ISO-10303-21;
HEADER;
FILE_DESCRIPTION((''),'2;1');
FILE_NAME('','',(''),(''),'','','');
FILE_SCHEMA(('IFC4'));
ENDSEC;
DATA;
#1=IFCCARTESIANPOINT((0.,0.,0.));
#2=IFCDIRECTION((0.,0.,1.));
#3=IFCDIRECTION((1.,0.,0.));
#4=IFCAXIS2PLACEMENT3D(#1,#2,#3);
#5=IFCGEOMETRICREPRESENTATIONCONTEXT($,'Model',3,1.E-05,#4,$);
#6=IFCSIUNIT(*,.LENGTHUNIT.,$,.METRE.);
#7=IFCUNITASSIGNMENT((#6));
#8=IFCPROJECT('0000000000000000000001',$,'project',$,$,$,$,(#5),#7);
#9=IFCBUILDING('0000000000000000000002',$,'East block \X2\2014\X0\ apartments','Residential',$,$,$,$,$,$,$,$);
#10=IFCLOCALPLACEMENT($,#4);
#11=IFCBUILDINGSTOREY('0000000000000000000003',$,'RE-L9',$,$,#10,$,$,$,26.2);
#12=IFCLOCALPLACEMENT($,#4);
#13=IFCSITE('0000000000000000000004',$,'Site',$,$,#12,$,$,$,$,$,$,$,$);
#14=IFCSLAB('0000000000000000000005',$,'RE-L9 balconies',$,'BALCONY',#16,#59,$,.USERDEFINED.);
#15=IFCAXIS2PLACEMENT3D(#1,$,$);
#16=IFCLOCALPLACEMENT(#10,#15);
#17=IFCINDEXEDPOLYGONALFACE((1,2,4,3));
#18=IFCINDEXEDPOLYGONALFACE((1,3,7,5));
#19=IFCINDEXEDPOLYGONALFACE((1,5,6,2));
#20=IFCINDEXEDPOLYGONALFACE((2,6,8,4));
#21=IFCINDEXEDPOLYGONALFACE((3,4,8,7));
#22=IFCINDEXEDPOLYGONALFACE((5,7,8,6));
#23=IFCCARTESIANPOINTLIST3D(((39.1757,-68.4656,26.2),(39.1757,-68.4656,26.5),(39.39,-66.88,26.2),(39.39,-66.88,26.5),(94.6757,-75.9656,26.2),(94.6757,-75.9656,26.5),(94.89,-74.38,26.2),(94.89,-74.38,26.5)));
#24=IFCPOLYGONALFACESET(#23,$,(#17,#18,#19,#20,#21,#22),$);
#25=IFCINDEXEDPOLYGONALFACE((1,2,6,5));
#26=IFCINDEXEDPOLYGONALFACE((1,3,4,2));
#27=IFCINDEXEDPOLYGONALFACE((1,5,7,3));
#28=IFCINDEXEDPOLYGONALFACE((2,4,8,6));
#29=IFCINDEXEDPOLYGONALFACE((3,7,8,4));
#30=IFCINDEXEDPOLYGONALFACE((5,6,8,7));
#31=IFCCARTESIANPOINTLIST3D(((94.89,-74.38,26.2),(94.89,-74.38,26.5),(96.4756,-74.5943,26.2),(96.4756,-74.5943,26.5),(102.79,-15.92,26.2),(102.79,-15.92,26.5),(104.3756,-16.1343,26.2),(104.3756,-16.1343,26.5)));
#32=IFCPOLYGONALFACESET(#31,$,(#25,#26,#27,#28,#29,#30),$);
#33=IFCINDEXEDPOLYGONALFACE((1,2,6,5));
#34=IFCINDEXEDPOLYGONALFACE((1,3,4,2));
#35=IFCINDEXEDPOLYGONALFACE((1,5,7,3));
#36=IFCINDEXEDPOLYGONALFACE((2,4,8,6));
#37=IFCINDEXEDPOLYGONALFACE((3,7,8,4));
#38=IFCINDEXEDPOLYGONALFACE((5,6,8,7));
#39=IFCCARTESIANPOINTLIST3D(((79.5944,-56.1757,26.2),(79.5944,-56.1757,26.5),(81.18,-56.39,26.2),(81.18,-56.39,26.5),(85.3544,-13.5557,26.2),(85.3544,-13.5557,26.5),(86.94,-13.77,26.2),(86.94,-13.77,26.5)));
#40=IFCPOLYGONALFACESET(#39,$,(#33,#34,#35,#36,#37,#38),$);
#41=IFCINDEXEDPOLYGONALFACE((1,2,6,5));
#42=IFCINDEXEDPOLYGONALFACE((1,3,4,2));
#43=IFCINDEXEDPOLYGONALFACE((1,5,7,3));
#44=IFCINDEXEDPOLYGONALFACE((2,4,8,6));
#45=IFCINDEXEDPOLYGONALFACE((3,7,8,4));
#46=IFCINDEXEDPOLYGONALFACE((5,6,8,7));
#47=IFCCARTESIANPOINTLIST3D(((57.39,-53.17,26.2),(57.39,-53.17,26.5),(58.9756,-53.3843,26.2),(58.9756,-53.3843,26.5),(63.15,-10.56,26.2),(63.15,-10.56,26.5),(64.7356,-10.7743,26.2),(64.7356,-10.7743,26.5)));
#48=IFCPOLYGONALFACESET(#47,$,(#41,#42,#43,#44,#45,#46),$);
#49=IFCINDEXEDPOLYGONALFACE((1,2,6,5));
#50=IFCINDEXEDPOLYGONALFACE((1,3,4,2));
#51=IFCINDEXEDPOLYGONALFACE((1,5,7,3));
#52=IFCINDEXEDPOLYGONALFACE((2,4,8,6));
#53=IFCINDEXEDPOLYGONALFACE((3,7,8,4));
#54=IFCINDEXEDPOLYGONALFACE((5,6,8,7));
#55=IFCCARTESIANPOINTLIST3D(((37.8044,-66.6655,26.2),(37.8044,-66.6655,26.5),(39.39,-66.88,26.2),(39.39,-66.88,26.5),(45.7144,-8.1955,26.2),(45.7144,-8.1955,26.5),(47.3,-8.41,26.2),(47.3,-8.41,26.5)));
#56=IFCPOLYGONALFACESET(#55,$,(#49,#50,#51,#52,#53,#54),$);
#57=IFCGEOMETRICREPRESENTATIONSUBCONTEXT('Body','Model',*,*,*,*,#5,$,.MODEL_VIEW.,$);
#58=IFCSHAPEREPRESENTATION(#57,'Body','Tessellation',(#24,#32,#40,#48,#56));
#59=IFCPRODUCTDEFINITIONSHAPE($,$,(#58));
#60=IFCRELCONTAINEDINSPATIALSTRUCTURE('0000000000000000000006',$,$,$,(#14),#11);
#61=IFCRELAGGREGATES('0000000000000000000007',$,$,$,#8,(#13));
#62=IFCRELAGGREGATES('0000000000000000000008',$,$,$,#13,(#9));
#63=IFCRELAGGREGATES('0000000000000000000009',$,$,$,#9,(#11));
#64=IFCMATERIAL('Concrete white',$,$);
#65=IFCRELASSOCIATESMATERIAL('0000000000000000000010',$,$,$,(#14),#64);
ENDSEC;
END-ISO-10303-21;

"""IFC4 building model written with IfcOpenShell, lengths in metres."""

from ifc_helpers import new_model, si_unit, frame, origin_with_axes, place, context, subcontext, project, spatial, polyline, outline, extrude, material, element, save


model = new_model("IFC4")

# Units and contexts
model_context = context("Model", 3, precision=1e-05, world=origin_with_axes())
body_context = subcontext(model_context, "Body", "Model", "MODEL_VIEW")
ifc_project = project(units=[si_unit("LENGTHUNIT", "METRE")], contexts=[model_context])

# Site, building, storey
site_placement = place(None, origin_with_axes())
site = spatial("IfcSite", under=ifc_project, at=site_placement, Name="Site")
building = spatial("IfcBuilding", under=site, Name="East block — apartments", Description="Residential")
storey_placement = place(None, origin_with_axes())
storey = spatial("IfcBuildingStorey", under=building, at=storey_placement, Name="RE-L9", Elevation=26.2)

# Slab
ifc_material_1 = material(Name="Concrete white")
slab_placement = place(storey_placement, origin_with_axes())
element("IfcSlab", 1, at=slab_placement, inside=storey, material=ifc_material_1, Name="RE-L9 balconies", ObjectType="BALCONY", PredefinedType="USERDEFINED", context=body_context, shape_type="SweptSolid", body=[
    extrude(outline(polyline([(39.39, -66.88), (94.89, -74.38), (94.6757, -75.9656), (39.1757, -68.4656), (39.39, -66.88)])), frame((0.0, 0.0, 26.2), z_axis=(0.0, 0.0, 1.0), x_axis=(1.0, 0.0, 0.0)), (0.0, 0.0, 1.0), 0.3),
    extrude(outline(polyline([(94.89, -74.38), (102.79, -15.92), (104.3756, -16.1343), (96.4756, -74.5943), (94.89, -74.38)])), frame((0.0, 0.0, 26.2), z_axis=(0.0, 0.0, 1.0), x_axis=(1.0, 0.0, 0.0)), (0.0, 0.0, 1.0), 0.3),
    extrude(outline(polyline([(86.94, -13.77), (81.18, -56.39), (79.5944, -56.1757), (85.3544, -13.5557), (86.94, -13.77)])), frame((0.0, 0.0, 26.2), z_axis=(0.0, 0.0, 1.0), x_axis=(1.0, 0.0, 0.0)), (0.0, 0.0, 1.0), 0.3),
    extrude(outline(polyline([(57.39, -53.17), (63.15, -10.56), (64.7356, -10.7743), (58.9756, -53.3843), (57.39, -53.17)])), frame((0.0, 0.0, 26.2), z_axis=(0.0, 0.0, 1.0), x_axis=(1.0, 0.0, 0.0)), (0.0, 0.0, 1.0), 0.3),
    extrude(outline(polyline([(47.3, -8.41), (39.39, -66.88), (37.8044, -66.6655), (45.7144, -8.1955), (47.3, -8.41)])), frame((0.0, 0.0, 26.2), z_axis=(0.0, 0.0, 1.0), x_axis=(1.0, 0.0, 0.0)), (0.0, 0.0, 1.0), 0.3),
])

save(model, "model.ifc")
